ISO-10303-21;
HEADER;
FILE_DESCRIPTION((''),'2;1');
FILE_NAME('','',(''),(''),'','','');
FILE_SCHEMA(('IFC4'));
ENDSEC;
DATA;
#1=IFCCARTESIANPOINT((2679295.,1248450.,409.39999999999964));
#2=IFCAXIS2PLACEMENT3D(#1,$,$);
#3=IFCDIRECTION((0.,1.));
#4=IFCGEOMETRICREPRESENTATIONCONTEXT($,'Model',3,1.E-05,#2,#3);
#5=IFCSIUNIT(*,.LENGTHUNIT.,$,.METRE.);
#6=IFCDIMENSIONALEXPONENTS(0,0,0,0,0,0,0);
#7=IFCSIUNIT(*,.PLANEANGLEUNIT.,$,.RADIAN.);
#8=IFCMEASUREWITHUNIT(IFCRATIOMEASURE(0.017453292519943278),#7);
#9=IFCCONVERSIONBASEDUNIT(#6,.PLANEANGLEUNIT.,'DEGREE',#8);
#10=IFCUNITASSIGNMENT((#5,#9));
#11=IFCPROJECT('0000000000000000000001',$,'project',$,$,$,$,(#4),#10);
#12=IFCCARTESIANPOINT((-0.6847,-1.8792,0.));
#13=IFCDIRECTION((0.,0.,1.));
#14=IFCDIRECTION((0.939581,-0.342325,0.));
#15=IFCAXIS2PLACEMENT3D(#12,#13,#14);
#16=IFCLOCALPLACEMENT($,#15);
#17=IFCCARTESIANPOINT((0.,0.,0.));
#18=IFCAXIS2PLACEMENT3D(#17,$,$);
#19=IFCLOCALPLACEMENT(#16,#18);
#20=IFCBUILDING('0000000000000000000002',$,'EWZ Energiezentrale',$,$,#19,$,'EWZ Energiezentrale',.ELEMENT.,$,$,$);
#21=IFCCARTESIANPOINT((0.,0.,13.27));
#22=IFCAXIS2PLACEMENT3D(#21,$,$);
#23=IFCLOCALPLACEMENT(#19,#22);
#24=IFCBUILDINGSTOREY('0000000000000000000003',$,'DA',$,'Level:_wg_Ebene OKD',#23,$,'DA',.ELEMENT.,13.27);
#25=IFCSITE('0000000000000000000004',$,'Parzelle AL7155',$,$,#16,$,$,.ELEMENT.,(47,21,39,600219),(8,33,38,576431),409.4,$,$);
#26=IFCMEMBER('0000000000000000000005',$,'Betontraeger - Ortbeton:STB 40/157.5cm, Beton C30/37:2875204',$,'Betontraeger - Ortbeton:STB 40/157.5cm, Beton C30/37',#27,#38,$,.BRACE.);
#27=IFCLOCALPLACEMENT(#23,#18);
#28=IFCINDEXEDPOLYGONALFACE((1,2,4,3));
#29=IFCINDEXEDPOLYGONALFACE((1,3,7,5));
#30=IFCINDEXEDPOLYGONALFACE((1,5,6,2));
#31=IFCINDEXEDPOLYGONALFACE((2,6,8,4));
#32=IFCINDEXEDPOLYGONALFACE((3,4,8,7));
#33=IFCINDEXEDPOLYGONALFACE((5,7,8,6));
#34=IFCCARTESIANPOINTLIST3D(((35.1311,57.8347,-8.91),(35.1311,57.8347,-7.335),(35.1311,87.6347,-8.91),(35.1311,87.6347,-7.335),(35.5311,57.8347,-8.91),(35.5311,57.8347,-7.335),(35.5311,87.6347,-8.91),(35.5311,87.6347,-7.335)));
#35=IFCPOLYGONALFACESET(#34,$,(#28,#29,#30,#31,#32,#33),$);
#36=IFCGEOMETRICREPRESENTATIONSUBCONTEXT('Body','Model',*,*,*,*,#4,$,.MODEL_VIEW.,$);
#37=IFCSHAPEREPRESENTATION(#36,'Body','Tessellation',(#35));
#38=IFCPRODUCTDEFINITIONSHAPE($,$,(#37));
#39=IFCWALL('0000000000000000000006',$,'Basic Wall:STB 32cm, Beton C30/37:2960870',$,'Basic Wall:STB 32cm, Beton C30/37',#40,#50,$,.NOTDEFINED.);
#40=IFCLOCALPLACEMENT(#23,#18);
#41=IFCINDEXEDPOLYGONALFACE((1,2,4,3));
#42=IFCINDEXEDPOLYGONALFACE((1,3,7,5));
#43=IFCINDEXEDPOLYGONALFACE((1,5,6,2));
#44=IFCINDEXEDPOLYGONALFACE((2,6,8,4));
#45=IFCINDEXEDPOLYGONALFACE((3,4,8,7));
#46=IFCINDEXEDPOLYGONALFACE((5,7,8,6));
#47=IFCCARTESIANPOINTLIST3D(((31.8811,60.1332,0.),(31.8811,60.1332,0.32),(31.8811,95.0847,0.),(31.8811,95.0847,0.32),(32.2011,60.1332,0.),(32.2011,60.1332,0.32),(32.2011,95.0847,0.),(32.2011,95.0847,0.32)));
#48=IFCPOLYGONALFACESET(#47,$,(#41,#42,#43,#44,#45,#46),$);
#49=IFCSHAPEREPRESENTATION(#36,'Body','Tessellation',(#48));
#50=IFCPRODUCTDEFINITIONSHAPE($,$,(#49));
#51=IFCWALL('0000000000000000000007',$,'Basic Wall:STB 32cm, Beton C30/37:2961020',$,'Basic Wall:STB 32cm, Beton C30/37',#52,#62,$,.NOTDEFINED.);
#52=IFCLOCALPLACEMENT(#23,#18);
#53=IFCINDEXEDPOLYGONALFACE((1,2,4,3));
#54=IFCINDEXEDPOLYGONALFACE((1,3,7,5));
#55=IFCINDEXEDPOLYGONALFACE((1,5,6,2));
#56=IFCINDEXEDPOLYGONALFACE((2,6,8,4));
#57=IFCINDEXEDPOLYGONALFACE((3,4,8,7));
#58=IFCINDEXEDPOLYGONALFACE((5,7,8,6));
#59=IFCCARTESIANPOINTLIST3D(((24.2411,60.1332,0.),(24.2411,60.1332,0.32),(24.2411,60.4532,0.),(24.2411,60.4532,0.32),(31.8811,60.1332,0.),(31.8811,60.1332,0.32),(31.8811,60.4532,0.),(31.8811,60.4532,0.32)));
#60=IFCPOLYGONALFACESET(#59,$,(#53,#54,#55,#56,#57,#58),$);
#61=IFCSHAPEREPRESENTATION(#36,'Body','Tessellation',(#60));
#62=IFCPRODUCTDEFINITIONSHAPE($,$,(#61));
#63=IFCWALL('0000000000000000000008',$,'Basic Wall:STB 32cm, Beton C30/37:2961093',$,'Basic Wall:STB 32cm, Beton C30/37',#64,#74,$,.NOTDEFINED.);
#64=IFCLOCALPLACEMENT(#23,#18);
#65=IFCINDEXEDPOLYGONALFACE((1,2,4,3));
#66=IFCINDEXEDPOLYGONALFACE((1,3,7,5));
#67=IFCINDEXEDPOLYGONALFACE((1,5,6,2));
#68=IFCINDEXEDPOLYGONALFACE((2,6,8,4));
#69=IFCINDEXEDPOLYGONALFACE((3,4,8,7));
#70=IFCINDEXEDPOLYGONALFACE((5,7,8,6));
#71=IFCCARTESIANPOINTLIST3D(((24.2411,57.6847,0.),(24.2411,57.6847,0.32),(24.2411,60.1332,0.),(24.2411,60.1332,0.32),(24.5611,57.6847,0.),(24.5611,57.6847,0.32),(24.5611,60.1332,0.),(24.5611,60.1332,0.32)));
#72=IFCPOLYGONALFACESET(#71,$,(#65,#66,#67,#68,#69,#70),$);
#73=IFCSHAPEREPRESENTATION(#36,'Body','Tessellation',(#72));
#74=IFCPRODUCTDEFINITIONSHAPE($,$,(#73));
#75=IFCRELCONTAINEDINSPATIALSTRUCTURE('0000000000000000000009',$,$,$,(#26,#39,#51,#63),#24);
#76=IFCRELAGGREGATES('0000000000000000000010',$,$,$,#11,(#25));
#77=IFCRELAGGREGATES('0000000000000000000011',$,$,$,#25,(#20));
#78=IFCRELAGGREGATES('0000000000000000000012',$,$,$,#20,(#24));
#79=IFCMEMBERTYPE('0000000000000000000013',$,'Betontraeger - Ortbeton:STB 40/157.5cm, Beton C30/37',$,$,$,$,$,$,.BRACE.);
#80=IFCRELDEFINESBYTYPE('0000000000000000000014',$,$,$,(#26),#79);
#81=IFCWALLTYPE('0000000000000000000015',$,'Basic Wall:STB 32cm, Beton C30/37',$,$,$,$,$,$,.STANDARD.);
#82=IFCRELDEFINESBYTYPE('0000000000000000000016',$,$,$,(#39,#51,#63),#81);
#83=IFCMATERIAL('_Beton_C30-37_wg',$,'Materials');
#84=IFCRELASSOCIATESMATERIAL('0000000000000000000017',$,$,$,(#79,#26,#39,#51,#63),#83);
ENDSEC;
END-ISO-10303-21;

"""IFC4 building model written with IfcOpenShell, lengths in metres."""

from ifc_helpers import new_model, entity, si_unit, converted_unit, direction, frame, origin, place, context, subcontext, project, spatial, indexed_curve, outline, extrude, source, transform, mapped, material, type_object, type_shapes, element, save


model = new_model("IFC4")

# Units and contexts
model_context = context("Model", 3, precision=1e-05, world=frame((2679295.0, 1248450.0, 409.39999999999964)), true_north=direction((0.0, 1.0)))
body_context = subcontext(model_context, "Body", "Model", "MODEL_VIEW")
ifc_project = project(units=[si_unit("LENGTHUNIT", "METRE"), converted_unit("PLANEANGLEUNIT", "DEGREE", entity("IfcRatioMeasure", 0.017453292519943278), si_unit("PLANEANGLEUNIT", "RADIAN"), dimensions=[0, 0, 0, 0, 0, 0, 0])], contexts=[model_context])

# Site, building, storey
site_placement = place(None, frame((-0.6847, -1.8792, 0.0), z_axis=(0.0, 0.0, 1.0), x_axis=(0.939581, -0.342325, 0.0)))
site = spatial("IfcSite", under=ifc_project, at=site_placement, Name="Parzelle AL7155", CompositionType="ELEMENT", RefLatitude=(47, 21, 39, 600219), RefLongitude=(8, 33, 38, 576431), RefElevation=409.4)
building_placement = place(site_placement, origin())
building = spatial("IfcBuilding", under=site, at=building_placement, Name="EWZ Energiezentrale", LongName="EWZ Energiezentrale", CompositionType="ELEMENT")
storey_placement = place(building_placement, frame((0.0, 0.0, 13.27)))
storey = spatial("IfcBuildingStorey", under=building, at=storey_placement, Name="DA", ObjectType="Level:_wg_Ebene OKD", LongName="DA", CompositionType="ELEMENT", Elevation=13.27)

# Member
ifc_material = material(Name="_Beton_C30-37_wg", Category="Materials")
member_type = type_object("IfcMemberType", Name="Betontraeger - Ortbeton:STB 40/157.5cm, Beton C30/37", PredefinedType="BRACE", material=ifc_material)
shared_shape = source(origin(), body_context, "Body", "SweptSolid", [
    extrude(outline(indexed_curve([(-0.2, -0.7875), (0.2, -0.7875), (0.2, 0.7875), (-0.2, 0.7875), (-0.2, -0.7875)], self_intersect=False)), frame((35.3311, 57.8347, 5.1475), z_axis=(0.0, 1.0, 0.0), x_axis=(-1.0, 0.0, 0.0)), (0.0, 0.0, 1.0), 29.8),
])
type_shapes(member_type, [shared_shape])
member_placement = place(storey_placement, frame((0.0, 0.0, -13.27)))
element("IfcMember", 1, at=member_placement, inside=storey, type_object=member_type, material=ifc_material, Name="Betontraeger - Ortbeton:STB 40/157.5cm, Beton C30/37:2875204", ObjectType="Betontraeger - Ortbeton:STB 40/157.5cm, Beton C30/37", PredefinedType="BRACE", context=body_context, shape_type="MappedRepresentation", body=[
    mapped(shared_shape, transform((0.0, 0.0, 0.0), scale=1.0)),
])

# Walls
wall_type = type_object("IfcWallType", Name="Basic Wall:STB 32cm, Beton C30/37", PredefinedType="STANDARD")
wall_1_placement = place(storey_placement, frame((32.0411, 95.0847, 0.0), z_axis=(0.0, 0.0, 1.0), x_axis=(0.0, -1.0, 0.0)))
element("IfcWall", 2, at=wall_1_placement, inside=storey, type_object=wall_type, material=ifc_material, Name="Basic Wall:STB 32cm, Beton C30/37:2960870", ObjectType="Basic Wall:STB 32cm, Beton C30/37", PredefinedType="NOTDEFINED", context=body_context, shape_type="SweptSolid", body=[
    extrude(outline(indexed_curve([(34.9514, 0.16), (0.0, 0.16), (0.0, -0.16), (34.9514, -0.16), (34.9514, 0.16)], self_intersect=False)), origin(), (0.0, 0.0, 1.0), 0.32),
])
wall_2_placement = place(storey_placement, frame((31.8811, 60.2932, 0.0), z_axis=(0.0, 0.0, 1.0), x_axis=(-1.0, 0.0, 0.0)))
element("IfcWall", 3, at=wall_2_placement, inside=storey, type_object=wall_type, material=ifc_material, Name="Basic Wall:STB 32cm, Beton C30/37:2961020", ObjectType="Basic Wall:STB 32cm, Beton C30/37", PredefinedType="NOTDEFINED", context=body_context, shape_type="SweptSolid", body=[
    extrude(outline(indexed_curve([(7.6399, 0.16), (0.0, 0.16), (0.0, -0.16), (7.6399, -0.16), (7.6399, 0.16)], self_intersect=False)), origin(), (0.0, 0.0, 1.0), 0.32),
])
wall_3_placement = place(storey_placement, frame((24.4011, 60.1332, 0.0), z_axis=(0.0, 0.0, 1.0), x_axis=(0.0, -1.0, 0.0)))
element("IfcWall", 4, at=wall_3_placement, inside=storey, type_object=wall_type, material=ifc_material, Name="Basic Wall:STB 32cm, Beton C30/37:2961093", ObjectType="Basic Wall:STB 32cm, Beton C30/37", PredefinedType="NOTDEFINED", context=body_context, shape_type="SweptSolid", body=[
    extrude(outline(indexed_curve([(2.4486, 0.16), (0.0, 0.16), (0.0, -0.16), (2.4486, -0.16), (2.4486, 0.16)], self_intersect=False)), origin(), (0.0, 0.0, 1.0), 0.32),
])

save(model, "model.ifc")
